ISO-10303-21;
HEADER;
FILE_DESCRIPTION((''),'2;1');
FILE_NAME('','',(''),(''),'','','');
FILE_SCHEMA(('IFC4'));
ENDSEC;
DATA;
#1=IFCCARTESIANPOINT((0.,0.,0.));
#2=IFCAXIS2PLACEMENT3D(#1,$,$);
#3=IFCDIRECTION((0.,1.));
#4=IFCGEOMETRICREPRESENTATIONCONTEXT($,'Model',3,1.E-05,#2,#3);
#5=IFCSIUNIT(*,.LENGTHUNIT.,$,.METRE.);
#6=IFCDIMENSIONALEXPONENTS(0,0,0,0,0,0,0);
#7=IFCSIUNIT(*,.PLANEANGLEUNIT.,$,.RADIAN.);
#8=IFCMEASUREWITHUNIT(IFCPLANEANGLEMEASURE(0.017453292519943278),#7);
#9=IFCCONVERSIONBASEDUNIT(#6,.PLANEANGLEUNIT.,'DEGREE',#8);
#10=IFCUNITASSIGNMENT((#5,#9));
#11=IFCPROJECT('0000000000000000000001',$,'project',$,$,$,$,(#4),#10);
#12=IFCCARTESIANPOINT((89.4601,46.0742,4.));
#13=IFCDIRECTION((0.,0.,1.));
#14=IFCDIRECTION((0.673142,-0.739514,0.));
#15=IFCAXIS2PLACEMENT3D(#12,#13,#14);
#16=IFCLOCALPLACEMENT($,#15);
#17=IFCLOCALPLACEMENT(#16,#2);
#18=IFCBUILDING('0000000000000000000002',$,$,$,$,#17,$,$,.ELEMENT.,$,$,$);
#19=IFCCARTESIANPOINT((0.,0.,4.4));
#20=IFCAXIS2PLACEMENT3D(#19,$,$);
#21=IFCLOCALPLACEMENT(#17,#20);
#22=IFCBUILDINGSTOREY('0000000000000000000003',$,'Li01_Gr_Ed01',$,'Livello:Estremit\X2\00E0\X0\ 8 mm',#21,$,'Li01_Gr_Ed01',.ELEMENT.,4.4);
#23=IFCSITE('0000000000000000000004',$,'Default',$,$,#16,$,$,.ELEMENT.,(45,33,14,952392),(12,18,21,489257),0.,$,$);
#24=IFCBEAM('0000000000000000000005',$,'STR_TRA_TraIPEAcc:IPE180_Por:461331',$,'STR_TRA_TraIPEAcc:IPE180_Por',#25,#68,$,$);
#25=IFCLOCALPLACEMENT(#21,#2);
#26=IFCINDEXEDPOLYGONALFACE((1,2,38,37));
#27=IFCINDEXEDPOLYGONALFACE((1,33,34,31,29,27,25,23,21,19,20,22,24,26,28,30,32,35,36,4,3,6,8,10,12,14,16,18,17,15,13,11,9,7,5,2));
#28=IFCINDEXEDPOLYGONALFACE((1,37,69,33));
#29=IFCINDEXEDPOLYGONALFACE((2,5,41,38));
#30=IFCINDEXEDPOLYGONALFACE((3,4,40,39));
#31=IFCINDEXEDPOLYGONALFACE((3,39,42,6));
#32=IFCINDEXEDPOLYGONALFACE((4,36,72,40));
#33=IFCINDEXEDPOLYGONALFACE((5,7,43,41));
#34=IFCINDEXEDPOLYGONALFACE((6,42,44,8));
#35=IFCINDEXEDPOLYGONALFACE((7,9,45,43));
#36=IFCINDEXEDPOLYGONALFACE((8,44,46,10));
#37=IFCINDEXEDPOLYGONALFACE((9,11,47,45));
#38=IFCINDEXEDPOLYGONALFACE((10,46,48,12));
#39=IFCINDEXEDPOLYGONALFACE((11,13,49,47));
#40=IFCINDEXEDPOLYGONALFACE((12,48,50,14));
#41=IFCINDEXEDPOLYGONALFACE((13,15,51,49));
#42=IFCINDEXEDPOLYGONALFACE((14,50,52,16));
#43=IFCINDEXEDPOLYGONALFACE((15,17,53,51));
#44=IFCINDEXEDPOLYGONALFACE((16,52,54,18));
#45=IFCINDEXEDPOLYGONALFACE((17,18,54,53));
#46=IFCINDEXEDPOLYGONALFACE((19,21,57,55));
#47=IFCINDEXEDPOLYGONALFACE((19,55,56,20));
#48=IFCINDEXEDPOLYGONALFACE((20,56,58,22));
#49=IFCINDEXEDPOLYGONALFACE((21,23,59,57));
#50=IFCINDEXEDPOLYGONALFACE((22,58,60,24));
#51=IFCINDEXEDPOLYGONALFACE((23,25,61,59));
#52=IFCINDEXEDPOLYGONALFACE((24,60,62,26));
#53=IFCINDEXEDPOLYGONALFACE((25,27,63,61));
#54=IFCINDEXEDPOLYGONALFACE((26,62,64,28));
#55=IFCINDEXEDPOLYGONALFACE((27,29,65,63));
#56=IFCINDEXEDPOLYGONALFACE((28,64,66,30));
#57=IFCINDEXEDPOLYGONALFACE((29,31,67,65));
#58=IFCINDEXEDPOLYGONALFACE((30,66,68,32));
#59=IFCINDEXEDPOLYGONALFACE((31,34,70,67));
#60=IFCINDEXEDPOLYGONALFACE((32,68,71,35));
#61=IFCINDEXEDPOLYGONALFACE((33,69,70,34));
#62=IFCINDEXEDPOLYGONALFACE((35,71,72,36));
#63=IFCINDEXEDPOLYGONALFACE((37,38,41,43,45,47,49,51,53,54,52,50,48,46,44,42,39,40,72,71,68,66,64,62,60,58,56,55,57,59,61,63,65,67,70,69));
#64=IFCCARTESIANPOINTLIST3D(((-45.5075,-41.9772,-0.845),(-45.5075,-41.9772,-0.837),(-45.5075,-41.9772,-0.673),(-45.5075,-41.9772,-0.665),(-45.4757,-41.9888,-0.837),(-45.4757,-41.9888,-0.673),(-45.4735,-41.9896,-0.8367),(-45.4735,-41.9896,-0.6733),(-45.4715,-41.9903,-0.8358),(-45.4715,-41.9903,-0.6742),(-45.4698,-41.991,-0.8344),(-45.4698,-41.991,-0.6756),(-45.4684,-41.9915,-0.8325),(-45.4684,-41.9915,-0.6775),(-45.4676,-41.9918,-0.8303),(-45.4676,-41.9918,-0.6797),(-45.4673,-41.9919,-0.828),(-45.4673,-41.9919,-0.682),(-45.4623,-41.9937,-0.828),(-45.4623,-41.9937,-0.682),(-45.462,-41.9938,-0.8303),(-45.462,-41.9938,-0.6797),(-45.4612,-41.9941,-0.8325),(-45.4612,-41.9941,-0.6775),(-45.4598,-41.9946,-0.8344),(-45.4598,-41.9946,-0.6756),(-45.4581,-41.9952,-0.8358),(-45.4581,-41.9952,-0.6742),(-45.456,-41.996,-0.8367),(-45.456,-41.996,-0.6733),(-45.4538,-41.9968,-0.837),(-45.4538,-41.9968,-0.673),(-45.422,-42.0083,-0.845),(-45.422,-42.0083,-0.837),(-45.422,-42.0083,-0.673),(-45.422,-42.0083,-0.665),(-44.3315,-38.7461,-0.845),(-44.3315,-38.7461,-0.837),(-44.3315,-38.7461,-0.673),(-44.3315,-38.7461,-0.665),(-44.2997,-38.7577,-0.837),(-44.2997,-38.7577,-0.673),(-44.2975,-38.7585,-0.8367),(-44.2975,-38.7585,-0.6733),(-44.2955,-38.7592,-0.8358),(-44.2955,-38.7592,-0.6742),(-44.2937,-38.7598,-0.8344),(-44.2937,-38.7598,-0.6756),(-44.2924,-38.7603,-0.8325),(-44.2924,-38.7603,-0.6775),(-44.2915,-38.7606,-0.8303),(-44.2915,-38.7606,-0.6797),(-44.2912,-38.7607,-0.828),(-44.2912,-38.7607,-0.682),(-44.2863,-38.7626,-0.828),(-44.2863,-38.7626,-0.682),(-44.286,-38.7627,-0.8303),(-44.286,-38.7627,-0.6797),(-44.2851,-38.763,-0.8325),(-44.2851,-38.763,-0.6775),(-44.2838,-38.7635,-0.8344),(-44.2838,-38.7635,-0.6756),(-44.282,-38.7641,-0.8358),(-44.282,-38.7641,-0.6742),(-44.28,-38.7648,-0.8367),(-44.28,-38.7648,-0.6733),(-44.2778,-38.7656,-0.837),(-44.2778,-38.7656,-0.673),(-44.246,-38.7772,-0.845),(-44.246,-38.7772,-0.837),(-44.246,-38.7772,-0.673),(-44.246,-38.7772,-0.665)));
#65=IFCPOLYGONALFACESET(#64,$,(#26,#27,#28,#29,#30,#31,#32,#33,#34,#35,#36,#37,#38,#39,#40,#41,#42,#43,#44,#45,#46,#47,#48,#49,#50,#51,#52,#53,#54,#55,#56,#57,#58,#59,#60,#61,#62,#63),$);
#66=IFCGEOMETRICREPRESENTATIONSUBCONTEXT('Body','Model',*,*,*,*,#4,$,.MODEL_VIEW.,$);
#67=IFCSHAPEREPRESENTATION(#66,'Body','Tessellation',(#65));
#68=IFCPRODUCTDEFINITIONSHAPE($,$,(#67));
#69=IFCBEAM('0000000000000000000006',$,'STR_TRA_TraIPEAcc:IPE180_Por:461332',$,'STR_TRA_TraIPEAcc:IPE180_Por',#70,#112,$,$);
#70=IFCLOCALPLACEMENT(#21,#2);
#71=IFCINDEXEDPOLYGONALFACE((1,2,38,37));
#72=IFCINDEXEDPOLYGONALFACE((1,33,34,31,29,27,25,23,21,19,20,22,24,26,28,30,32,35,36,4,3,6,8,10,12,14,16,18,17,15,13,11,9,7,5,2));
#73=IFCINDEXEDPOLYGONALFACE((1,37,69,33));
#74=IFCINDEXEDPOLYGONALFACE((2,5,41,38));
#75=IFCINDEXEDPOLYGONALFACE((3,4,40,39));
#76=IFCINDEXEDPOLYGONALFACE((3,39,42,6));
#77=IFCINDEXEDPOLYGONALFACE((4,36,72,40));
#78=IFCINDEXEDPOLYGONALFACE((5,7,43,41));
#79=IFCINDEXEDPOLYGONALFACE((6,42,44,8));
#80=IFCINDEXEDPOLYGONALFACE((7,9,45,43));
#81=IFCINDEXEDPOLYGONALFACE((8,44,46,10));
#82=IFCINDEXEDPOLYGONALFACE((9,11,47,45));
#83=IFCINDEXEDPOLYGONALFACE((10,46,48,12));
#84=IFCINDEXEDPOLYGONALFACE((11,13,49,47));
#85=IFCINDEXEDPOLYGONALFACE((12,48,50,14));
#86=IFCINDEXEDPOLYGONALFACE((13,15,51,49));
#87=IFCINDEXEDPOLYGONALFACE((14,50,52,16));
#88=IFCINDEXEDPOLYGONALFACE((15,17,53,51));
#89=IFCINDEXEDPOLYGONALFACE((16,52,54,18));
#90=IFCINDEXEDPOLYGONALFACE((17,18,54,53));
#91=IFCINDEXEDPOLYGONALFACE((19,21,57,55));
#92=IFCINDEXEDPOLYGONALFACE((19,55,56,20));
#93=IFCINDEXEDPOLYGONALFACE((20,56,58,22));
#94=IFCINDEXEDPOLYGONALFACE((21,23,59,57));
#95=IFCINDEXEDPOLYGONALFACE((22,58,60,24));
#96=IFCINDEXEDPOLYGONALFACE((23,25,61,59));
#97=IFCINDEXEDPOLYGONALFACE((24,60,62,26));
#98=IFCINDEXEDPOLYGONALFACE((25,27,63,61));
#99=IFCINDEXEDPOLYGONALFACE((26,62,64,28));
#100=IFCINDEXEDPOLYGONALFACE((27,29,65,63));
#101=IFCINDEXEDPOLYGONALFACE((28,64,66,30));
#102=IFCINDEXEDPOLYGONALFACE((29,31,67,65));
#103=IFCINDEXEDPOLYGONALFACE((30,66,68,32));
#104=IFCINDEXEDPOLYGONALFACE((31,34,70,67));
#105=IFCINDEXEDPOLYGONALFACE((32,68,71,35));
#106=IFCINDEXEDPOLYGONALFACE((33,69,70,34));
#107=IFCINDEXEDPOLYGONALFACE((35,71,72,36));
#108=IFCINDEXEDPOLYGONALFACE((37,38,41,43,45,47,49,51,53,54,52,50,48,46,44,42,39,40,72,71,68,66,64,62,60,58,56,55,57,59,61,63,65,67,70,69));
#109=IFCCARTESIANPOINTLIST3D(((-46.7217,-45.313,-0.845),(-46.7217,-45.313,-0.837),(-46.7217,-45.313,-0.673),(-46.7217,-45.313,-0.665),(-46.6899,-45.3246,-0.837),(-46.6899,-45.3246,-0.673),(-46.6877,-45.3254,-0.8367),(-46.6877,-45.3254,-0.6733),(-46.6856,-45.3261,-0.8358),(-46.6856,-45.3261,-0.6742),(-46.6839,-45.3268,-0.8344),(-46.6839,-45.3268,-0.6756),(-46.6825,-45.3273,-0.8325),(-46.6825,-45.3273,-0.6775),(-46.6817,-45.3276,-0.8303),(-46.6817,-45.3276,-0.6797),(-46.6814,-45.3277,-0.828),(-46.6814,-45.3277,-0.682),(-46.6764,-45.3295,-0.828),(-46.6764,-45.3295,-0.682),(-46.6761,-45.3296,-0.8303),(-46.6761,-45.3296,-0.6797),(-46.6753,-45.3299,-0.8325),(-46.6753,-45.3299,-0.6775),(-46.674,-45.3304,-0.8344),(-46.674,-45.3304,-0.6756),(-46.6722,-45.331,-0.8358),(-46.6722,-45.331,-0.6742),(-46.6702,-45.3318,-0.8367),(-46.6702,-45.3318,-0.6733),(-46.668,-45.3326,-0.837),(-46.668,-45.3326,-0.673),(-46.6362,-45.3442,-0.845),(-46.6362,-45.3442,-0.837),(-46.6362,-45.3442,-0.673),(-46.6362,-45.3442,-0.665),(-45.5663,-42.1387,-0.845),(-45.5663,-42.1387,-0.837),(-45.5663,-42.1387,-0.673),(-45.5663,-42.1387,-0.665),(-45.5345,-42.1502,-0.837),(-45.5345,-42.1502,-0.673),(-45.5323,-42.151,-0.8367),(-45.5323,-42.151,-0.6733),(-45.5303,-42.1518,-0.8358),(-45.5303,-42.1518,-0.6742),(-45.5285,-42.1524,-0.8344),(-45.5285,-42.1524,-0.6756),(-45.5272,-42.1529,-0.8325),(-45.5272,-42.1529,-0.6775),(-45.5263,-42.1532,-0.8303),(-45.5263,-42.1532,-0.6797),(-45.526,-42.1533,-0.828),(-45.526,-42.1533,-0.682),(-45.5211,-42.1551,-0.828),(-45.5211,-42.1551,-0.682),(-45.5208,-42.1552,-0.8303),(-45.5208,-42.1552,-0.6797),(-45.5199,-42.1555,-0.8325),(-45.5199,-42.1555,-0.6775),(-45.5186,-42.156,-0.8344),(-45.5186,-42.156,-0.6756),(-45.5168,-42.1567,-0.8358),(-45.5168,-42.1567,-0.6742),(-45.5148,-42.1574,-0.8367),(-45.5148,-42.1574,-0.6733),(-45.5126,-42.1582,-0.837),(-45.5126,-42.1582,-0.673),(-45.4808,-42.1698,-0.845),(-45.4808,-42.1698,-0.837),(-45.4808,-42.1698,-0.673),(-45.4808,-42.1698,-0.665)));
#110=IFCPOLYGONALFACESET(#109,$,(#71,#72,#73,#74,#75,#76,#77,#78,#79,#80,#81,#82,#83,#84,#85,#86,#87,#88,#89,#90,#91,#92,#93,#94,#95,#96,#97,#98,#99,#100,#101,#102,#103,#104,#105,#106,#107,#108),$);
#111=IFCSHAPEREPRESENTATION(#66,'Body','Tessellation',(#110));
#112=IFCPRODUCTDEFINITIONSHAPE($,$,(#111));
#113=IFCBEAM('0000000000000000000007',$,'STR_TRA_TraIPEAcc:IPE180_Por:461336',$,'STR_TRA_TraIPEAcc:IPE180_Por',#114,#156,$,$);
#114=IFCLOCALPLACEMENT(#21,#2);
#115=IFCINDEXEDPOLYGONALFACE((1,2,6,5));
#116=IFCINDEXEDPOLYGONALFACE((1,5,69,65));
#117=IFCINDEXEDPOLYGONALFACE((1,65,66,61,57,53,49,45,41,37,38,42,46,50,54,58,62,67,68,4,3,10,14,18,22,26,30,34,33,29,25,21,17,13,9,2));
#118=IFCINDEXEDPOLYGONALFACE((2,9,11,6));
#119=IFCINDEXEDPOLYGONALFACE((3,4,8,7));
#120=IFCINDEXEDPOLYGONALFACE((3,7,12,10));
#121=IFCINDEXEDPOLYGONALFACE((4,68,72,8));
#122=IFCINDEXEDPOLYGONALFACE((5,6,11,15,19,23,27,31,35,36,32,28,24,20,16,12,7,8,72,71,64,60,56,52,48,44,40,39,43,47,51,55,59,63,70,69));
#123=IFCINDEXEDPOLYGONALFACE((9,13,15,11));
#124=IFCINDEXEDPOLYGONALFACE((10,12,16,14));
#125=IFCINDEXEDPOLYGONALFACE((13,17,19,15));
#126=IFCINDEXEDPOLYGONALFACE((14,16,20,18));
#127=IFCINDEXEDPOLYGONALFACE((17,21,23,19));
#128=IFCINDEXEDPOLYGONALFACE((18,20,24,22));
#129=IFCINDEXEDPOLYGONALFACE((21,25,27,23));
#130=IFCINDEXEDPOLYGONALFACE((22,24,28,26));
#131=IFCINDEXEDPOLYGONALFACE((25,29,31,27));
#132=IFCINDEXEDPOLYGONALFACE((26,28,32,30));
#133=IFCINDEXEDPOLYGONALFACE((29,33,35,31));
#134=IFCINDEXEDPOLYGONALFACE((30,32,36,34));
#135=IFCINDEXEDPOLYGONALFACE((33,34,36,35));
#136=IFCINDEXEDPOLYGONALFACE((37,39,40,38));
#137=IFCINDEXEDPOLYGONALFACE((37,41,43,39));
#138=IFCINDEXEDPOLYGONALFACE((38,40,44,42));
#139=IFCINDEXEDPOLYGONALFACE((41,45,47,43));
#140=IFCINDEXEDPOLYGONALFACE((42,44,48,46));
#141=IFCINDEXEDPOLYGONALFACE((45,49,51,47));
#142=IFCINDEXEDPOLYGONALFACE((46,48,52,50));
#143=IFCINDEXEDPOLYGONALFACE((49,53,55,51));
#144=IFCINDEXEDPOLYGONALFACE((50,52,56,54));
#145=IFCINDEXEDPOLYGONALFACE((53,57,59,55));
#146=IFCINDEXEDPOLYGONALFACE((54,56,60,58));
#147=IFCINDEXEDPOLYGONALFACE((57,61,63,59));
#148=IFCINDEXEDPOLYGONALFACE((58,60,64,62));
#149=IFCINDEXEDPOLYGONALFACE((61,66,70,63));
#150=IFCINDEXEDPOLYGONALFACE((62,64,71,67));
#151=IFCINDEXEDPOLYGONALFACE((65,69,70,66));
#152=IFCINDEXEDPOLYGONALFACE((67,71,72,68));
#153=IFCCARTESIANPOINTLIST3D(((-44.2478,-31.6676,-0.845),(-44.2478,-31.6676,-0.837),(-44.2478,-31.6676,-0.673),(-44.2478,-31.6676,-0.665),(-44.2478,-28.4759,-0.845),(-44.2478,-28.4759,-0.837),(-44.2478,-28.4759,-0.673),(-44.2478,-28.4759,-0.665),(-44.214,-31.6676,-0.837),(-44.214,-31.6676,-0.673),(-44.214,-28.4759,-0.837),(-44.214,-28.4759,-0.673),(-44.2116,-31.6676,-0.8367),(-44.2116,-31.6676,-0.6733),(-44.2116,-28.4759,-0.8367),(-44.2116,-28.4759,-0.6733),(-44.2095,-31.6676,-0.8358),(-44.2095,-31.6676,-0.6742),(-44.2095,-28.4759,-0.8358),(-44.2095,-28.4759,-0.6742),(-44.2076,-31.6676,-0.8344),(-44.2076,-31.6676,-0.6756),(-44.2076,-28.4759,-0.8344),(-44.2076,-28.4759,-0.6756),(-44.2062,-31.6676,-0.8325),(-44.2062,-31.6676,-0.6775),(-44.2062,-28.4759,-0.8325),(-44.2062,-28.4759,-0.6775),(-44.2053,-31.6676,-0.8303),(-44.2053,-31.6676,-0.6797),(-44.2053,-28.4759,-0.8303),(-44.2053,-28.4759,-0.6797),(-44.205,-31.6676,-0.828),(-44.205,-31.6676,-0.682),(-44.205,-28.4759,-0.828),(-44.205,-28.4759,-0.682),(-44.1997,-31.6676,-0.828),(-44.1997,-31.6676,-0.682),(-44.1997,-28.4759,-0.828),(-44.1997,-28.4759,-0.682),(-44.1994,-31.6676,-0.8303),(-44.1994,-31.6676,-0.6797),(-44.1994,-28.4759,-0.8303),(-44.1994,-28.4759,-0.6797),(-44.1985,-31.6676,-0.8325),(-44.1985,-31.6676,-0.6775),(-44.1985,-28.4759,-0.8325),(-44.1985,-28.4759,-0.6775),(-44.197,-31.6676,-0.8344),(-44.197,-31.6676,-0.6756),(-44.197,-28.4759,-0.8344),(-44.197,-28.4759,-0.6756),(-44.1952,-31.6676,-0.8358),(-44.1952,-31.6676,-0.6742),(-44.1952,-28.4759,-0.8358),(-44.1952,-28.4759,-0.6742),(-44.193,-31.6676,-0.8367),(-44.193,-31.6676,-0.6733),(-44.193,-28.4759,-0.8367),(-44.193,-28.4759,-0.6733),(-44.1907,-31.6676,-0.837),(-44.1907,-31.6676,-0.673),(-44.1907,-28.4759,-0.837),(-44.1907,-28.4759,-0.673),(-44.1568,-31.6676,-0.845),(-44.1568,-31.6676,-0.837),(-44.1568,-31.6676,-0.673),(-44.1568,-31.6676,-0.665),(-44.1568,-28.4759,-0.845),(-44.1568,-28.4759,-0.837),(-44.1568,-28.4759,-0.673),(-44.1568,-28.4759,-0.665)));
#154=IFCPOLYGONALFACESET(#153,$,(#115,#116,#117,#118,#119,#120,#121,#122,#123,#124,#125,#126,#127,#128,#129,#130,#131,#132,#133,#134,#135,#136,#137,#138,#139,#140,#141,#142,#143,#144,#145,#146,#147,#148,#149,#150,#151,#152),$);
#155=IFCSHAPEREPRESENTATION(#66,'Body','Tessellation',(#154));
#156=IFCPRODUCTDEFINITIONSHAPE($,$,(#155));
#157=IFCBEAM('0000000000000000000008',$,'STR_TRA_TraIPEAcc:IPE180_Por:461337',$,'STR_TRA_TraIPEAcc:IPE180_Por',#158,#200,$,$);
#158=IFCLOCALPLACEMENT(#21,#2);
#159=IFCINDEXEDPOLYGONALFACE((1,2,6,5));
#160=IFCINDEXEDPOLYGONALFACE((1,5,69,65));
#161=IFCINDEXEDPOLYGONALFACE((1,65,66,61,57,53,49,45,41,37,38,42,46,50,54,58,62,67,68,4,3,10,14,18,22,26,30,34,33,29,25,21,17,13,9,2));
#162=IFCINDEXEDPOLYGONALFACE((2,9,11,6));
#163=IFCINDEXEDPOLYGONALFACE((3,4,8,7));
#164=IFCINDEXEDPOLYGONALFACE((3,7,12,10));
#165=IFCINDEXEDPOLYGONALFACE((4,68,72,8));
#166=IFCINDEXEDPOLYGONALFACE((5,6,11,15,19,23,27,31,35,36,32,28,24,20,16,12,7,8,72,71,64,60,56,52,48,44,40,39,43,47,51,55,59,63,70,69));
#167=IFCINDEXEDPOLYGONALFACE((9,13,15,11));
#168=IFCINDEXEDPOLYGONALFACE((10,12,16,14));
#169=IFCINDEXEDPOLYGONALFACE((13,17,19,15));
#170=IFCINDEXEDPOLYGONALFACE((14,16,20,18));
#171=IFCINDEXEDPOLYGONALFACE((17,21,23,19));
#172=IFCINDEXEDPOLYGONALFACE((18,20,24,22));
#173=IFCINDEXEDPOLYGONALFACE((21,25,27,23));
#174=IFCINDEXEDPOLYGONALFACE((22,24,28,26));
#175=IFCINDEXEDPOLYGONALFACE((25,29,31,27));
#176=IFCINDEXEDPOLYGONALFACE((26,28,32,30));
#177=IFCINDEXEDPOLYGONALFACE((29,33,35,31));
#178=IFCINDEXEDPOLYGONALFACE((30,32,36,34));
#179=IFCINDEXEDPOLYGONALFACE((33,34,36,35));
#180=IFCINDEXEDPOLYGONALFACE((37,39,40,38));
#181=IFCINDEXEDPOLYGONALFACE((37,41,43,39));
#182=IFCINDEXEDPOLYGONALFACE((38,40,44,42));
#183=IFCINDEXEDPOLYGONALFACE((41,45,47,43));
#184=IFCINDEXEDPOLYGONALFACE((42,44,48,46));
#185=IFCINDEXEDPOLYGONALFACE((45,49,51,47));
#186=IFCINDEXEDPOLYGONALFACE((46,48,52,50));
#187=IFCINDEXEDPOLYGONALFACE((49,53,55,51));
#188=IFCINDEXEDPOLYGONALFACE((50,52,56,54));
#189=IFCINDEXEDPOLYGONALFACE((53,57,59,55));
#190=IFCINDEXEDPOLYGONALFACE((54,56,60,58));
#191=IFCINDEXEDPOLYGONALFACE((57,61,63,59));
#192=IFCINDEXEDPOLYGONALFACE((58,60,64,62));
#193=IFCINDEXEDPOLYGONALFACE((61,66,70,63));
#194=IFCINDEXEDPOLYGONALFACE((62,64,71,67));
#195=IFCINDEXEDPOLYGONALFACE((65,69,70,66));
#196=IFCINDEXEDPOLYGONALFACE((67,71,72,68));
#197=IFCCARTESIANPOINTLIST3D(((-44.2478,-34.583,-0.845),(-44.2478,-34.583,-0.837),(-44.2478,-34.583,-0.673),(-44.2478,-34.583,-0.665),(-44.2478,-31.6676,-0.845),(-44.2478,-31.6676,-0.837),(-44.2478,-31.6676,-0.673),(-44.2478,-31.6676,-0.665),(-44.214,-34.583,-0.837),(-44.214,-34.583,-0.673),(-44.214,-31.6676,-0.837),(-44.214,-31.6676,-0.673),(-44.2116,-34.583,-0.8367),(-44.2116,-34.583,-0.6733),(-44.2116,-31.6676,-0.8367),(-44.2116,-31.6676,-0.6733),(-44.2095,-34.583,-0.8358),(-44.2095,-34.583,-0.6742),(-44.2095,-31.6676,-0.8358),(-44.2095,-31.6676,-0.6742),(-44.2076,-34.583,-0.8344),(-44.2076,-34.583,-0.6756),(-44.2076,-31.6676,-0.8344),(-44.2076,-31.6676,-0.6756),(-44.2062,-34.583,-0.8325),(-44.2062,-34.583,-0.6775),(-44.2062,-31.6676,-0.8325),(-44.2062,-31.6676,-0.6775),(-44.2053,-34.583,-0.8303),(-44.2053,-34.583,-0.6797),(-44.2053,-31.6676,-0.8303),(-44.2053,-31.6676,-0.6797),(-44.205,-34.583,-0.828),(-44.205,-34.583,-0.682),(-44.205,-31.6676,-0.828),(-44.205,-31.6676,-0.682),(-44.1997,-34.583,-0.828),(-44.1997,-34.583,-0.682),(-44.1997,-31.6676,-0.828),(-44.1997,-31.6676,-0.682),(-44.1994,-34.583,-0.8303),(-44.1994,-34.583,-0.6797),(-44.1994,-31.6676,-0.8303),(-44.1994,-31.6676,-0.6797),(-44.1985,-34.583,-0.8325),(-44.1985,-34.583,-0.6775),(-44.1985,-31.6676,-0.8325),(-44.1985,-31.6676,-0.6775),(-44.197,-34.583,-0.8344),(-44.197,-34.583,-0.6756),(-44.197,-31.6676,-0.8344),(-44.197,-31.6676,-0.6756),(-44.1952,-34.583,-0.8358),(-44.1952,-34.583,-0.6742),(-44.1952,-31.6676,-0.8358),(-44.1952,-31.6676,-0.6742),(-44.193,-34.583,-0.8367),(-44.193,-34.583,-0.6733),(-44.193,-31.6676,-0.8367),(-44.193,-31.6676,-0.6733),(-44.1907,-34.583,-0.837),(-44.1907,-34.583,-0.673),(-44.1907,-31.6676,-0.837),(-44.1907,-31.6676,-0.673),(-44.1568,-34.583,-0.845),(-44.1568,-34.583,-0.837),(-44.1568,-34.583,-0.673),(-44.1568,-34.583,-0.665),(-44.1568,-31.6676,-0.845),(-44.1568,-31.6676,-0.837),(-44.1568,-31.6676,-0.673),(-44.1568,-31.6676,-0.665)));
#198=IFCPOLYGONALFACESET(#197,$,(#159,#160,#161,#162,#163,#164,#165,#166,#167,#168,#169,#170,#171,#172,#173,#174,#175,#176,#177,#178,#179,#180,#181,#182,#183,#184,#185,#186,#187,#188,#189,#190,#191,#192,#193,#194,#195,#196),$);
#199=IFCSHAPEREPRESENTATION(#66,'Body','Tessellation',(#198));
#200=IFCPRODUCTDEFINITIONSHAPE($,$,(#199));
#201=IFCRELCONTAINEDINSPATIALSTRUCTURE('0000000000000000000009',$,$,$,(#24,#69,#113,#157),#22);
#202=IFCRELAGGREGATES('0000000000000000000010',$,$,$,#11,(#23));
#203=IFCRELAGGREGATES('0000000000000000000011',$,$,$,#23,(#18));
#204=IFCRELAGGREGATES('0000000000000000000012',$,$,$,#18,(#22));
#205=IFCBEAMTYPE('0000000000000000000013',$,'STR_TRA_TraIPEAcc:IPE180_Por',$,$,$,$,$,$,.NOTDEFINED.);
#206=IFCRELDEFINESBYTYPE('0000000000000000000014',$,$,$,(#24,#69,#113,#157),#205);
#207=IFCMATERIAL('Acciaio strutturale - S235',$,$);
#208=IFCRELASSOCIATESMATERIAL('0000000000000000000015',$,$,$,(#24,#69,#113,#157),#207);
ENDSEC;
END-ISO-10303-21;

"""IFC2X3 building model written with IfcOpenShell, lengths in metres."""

from ifc_helpers import new_model, entity, si_unit, converted_unit, direction, frame, frame_2d, origin, place, context, subcontext, project, spatial, i_section, extrude, material, type_object, element, save


model = new_model("IFC2X3")

# Units and contexts
model_context = context("Model", 3, precision=1e-05, world=origin(), true_north=direction((0.0, 1.0)))
body_context = subcontext(model_context, "Body", "Model", "MODEL_VIEW")
ifc_project = project(units=[si_unit("LENGTHUNIT", "METRE"), converted_unit("PLANEANGLEUNIT", "DEGREE", entity("IfcPlaneAngleMeasure", 0.017453292519943278), si_unit("PLANEANGLEUNIT", "RADIAN"), dimensions=[0, 0, 0, 0, 0, 0, 0])], contexts=[model_context])

# Site, building, storey
site_placement = place(None, frame((89.4601, 46.0742, 4.0), z_axis=(0.0, 0.0, 1.0), x_axis=(0.673142, -0.739514, 0.0)))
site = spatial("IfcSite", under=ifc_project, at=site_placement, Name="Default", CompositionType="ELEMENT", RefLatitude=(45, 33, 14, 952392), RefLongitude=(12, 18, 21, 489257), RefElevation=0.0)
building_placement = place(site_placement, origin())
building = spatial("IfcBuilding", under=site, at=building_placement, CompositionType="ELEMENT")
storey_placement = place(building_placement, frame((0.0, 0.0, 4.4)))
storey = spatial("IfcBuildingStorey", under=building, at=storey_placement, Name="Li01_Gr_Ed01", ObjectType="Livello:Estremità 8 mm", LongName="Li01_Gr_Ed01", CompositionType="ELEMENT", Elevation=4.4)

# Beams
ifc_material_1 = material(Name="Acciaio strutturale - S235")
beam_type = type_object("IfcBeamType", Name="STR_TRA_TraIPEAcc:IPE180_Por", PredefinedType="NOTDEFINED")
beam_1_placement = place(storey_placement, frame((-44.238, -38.6222, -0.665), z_axis=(0.0, 0.0, 1.0), x_axis=(-0.34202, -0.939693, 0.0)))
element("IfcBeam", 1, at=beam_1_placement, inside=storey, type_object=beam_type, material=ifc_material_1, Name="STR_TRA_TraIPEAcc:IPE180_Por:461331", ObjectType="STR_TRA_TraIPEAcc:IPE180_Por", context=body_context, shape_type="SweptSolid", body=[
    extrude(i_section(OverallWidth=0.091, OverallDepth=0.18, WebThickness=0.0053, FlangeThickness=0.008, FilletRadius=0.009, at=frame_2d((0.0, 0.0), x_axis=(0.0, 1.0))), frame((0.1484, 0.0, -0.09), z_axis=(1.0, 0.0, 0.0), x_axis=(0.0, 0.0, -1.0)), (0.0, 0.0, 1.0), 3.4385),
])
beam_2_placement = place(storey_placement, frame((-45.4693, -42.0052, -0.665), z_axis=(0.0, 0.0, 1.0), x_axis=(-0.34202, -0.939693, 0.0)))
element("IfcBeam", 2, at=beam_2_placement, inside=storey, type_object=beam_type, material=ifc_material_1, Name="STR_TRA_TraIPEAcc:IPE180_Por:461332", ObjectType="STR_TRA_TraIPEAcc:IPE180_Por", context=body_context, shape_type="SweptSolid", body=[
    extrude(i_section(OverallWidth=0.091, OverallDepth=0.18, WebThickness=0.0053, FlangeThickness=0.008, FilletRadius=0.009, at=frame_2d((0.0, 0.0), x_axis=(0.0, 1.0))), frame((0.1585, 0.0, -0.09), z_axis=(1.0, 0.0, 0.0), x_axis=(0.0, 0.0, -1.0)), (0.0, 0.0, 1.0), 3.3781),
])
beam_3_placement = place(storey_placement, frame((-44.2023, -31.0363, -0.665), z_axis=(0.0, 0.0, 1.0), x_axis=(0.0, 1.0, 0.0)))
element("IfcBeam", 3, at=beam_3_placement, inside=storey, type_object=beam_type, material=ifc_material_1, Name="STR_TRA_TraIPEAcc:IPE180_Por:461336", ObjectType="STR_TRA_TraIPEAcc:IPE180_Por", context=body_context, shape_type="SweptSolid", body=[
    extrude(i_section(OverallWidth=0.091, OverallDepth=0.18, WebThickness=0.0053, FlangeThickness=0.008, FilletRadius=0.009, at=frame_2d((0.0, 0.0), x_axis=(0.0, 1.0))), frame((-0.6313, 0.0, -0.09), z_axis=(1.0, 0.0, 0.0), x_axis=(0.0, 0.0, -1.0)), (0.0, 0.0, 1.0), 3.1917),
])
beam_4_placement = place(storey_placement, frame((-44.2023, -34.657, -0.665), z_axis=(0.0, 0.0, 1.0), x_axis=(0.0, 1.0, 0.0)))
element("IfcBeam", 4, at=beam_4_placement, inside=storey, type_object=beam_type, material=ifc_material_1, Name="STR_TRA_TraIPEAcc:IPE180_Por:461337", ObjectType="STR_TRA_TraIPEAcc:IPE180_Por", context=body_context, shape_type="SweptSolid", body=[
    extrude(i_section(OverallWidth=0.091, OverallDepth=0.18, WebThickness=0.0053, FlangeThickness=0.008, FilletRadius=0.009, at=frame_2d((0.0, 0.0), x_axis=(0.0, 1.0))), frame((0.074, 0.0, -0.09), z_axis=(1.0, 0.0, 0.0), x_axis=(0.0, 0.0, -1.0)), (0.0, 0.0, 1.0), 2.9153),
])

save(model, "model.ifc")
